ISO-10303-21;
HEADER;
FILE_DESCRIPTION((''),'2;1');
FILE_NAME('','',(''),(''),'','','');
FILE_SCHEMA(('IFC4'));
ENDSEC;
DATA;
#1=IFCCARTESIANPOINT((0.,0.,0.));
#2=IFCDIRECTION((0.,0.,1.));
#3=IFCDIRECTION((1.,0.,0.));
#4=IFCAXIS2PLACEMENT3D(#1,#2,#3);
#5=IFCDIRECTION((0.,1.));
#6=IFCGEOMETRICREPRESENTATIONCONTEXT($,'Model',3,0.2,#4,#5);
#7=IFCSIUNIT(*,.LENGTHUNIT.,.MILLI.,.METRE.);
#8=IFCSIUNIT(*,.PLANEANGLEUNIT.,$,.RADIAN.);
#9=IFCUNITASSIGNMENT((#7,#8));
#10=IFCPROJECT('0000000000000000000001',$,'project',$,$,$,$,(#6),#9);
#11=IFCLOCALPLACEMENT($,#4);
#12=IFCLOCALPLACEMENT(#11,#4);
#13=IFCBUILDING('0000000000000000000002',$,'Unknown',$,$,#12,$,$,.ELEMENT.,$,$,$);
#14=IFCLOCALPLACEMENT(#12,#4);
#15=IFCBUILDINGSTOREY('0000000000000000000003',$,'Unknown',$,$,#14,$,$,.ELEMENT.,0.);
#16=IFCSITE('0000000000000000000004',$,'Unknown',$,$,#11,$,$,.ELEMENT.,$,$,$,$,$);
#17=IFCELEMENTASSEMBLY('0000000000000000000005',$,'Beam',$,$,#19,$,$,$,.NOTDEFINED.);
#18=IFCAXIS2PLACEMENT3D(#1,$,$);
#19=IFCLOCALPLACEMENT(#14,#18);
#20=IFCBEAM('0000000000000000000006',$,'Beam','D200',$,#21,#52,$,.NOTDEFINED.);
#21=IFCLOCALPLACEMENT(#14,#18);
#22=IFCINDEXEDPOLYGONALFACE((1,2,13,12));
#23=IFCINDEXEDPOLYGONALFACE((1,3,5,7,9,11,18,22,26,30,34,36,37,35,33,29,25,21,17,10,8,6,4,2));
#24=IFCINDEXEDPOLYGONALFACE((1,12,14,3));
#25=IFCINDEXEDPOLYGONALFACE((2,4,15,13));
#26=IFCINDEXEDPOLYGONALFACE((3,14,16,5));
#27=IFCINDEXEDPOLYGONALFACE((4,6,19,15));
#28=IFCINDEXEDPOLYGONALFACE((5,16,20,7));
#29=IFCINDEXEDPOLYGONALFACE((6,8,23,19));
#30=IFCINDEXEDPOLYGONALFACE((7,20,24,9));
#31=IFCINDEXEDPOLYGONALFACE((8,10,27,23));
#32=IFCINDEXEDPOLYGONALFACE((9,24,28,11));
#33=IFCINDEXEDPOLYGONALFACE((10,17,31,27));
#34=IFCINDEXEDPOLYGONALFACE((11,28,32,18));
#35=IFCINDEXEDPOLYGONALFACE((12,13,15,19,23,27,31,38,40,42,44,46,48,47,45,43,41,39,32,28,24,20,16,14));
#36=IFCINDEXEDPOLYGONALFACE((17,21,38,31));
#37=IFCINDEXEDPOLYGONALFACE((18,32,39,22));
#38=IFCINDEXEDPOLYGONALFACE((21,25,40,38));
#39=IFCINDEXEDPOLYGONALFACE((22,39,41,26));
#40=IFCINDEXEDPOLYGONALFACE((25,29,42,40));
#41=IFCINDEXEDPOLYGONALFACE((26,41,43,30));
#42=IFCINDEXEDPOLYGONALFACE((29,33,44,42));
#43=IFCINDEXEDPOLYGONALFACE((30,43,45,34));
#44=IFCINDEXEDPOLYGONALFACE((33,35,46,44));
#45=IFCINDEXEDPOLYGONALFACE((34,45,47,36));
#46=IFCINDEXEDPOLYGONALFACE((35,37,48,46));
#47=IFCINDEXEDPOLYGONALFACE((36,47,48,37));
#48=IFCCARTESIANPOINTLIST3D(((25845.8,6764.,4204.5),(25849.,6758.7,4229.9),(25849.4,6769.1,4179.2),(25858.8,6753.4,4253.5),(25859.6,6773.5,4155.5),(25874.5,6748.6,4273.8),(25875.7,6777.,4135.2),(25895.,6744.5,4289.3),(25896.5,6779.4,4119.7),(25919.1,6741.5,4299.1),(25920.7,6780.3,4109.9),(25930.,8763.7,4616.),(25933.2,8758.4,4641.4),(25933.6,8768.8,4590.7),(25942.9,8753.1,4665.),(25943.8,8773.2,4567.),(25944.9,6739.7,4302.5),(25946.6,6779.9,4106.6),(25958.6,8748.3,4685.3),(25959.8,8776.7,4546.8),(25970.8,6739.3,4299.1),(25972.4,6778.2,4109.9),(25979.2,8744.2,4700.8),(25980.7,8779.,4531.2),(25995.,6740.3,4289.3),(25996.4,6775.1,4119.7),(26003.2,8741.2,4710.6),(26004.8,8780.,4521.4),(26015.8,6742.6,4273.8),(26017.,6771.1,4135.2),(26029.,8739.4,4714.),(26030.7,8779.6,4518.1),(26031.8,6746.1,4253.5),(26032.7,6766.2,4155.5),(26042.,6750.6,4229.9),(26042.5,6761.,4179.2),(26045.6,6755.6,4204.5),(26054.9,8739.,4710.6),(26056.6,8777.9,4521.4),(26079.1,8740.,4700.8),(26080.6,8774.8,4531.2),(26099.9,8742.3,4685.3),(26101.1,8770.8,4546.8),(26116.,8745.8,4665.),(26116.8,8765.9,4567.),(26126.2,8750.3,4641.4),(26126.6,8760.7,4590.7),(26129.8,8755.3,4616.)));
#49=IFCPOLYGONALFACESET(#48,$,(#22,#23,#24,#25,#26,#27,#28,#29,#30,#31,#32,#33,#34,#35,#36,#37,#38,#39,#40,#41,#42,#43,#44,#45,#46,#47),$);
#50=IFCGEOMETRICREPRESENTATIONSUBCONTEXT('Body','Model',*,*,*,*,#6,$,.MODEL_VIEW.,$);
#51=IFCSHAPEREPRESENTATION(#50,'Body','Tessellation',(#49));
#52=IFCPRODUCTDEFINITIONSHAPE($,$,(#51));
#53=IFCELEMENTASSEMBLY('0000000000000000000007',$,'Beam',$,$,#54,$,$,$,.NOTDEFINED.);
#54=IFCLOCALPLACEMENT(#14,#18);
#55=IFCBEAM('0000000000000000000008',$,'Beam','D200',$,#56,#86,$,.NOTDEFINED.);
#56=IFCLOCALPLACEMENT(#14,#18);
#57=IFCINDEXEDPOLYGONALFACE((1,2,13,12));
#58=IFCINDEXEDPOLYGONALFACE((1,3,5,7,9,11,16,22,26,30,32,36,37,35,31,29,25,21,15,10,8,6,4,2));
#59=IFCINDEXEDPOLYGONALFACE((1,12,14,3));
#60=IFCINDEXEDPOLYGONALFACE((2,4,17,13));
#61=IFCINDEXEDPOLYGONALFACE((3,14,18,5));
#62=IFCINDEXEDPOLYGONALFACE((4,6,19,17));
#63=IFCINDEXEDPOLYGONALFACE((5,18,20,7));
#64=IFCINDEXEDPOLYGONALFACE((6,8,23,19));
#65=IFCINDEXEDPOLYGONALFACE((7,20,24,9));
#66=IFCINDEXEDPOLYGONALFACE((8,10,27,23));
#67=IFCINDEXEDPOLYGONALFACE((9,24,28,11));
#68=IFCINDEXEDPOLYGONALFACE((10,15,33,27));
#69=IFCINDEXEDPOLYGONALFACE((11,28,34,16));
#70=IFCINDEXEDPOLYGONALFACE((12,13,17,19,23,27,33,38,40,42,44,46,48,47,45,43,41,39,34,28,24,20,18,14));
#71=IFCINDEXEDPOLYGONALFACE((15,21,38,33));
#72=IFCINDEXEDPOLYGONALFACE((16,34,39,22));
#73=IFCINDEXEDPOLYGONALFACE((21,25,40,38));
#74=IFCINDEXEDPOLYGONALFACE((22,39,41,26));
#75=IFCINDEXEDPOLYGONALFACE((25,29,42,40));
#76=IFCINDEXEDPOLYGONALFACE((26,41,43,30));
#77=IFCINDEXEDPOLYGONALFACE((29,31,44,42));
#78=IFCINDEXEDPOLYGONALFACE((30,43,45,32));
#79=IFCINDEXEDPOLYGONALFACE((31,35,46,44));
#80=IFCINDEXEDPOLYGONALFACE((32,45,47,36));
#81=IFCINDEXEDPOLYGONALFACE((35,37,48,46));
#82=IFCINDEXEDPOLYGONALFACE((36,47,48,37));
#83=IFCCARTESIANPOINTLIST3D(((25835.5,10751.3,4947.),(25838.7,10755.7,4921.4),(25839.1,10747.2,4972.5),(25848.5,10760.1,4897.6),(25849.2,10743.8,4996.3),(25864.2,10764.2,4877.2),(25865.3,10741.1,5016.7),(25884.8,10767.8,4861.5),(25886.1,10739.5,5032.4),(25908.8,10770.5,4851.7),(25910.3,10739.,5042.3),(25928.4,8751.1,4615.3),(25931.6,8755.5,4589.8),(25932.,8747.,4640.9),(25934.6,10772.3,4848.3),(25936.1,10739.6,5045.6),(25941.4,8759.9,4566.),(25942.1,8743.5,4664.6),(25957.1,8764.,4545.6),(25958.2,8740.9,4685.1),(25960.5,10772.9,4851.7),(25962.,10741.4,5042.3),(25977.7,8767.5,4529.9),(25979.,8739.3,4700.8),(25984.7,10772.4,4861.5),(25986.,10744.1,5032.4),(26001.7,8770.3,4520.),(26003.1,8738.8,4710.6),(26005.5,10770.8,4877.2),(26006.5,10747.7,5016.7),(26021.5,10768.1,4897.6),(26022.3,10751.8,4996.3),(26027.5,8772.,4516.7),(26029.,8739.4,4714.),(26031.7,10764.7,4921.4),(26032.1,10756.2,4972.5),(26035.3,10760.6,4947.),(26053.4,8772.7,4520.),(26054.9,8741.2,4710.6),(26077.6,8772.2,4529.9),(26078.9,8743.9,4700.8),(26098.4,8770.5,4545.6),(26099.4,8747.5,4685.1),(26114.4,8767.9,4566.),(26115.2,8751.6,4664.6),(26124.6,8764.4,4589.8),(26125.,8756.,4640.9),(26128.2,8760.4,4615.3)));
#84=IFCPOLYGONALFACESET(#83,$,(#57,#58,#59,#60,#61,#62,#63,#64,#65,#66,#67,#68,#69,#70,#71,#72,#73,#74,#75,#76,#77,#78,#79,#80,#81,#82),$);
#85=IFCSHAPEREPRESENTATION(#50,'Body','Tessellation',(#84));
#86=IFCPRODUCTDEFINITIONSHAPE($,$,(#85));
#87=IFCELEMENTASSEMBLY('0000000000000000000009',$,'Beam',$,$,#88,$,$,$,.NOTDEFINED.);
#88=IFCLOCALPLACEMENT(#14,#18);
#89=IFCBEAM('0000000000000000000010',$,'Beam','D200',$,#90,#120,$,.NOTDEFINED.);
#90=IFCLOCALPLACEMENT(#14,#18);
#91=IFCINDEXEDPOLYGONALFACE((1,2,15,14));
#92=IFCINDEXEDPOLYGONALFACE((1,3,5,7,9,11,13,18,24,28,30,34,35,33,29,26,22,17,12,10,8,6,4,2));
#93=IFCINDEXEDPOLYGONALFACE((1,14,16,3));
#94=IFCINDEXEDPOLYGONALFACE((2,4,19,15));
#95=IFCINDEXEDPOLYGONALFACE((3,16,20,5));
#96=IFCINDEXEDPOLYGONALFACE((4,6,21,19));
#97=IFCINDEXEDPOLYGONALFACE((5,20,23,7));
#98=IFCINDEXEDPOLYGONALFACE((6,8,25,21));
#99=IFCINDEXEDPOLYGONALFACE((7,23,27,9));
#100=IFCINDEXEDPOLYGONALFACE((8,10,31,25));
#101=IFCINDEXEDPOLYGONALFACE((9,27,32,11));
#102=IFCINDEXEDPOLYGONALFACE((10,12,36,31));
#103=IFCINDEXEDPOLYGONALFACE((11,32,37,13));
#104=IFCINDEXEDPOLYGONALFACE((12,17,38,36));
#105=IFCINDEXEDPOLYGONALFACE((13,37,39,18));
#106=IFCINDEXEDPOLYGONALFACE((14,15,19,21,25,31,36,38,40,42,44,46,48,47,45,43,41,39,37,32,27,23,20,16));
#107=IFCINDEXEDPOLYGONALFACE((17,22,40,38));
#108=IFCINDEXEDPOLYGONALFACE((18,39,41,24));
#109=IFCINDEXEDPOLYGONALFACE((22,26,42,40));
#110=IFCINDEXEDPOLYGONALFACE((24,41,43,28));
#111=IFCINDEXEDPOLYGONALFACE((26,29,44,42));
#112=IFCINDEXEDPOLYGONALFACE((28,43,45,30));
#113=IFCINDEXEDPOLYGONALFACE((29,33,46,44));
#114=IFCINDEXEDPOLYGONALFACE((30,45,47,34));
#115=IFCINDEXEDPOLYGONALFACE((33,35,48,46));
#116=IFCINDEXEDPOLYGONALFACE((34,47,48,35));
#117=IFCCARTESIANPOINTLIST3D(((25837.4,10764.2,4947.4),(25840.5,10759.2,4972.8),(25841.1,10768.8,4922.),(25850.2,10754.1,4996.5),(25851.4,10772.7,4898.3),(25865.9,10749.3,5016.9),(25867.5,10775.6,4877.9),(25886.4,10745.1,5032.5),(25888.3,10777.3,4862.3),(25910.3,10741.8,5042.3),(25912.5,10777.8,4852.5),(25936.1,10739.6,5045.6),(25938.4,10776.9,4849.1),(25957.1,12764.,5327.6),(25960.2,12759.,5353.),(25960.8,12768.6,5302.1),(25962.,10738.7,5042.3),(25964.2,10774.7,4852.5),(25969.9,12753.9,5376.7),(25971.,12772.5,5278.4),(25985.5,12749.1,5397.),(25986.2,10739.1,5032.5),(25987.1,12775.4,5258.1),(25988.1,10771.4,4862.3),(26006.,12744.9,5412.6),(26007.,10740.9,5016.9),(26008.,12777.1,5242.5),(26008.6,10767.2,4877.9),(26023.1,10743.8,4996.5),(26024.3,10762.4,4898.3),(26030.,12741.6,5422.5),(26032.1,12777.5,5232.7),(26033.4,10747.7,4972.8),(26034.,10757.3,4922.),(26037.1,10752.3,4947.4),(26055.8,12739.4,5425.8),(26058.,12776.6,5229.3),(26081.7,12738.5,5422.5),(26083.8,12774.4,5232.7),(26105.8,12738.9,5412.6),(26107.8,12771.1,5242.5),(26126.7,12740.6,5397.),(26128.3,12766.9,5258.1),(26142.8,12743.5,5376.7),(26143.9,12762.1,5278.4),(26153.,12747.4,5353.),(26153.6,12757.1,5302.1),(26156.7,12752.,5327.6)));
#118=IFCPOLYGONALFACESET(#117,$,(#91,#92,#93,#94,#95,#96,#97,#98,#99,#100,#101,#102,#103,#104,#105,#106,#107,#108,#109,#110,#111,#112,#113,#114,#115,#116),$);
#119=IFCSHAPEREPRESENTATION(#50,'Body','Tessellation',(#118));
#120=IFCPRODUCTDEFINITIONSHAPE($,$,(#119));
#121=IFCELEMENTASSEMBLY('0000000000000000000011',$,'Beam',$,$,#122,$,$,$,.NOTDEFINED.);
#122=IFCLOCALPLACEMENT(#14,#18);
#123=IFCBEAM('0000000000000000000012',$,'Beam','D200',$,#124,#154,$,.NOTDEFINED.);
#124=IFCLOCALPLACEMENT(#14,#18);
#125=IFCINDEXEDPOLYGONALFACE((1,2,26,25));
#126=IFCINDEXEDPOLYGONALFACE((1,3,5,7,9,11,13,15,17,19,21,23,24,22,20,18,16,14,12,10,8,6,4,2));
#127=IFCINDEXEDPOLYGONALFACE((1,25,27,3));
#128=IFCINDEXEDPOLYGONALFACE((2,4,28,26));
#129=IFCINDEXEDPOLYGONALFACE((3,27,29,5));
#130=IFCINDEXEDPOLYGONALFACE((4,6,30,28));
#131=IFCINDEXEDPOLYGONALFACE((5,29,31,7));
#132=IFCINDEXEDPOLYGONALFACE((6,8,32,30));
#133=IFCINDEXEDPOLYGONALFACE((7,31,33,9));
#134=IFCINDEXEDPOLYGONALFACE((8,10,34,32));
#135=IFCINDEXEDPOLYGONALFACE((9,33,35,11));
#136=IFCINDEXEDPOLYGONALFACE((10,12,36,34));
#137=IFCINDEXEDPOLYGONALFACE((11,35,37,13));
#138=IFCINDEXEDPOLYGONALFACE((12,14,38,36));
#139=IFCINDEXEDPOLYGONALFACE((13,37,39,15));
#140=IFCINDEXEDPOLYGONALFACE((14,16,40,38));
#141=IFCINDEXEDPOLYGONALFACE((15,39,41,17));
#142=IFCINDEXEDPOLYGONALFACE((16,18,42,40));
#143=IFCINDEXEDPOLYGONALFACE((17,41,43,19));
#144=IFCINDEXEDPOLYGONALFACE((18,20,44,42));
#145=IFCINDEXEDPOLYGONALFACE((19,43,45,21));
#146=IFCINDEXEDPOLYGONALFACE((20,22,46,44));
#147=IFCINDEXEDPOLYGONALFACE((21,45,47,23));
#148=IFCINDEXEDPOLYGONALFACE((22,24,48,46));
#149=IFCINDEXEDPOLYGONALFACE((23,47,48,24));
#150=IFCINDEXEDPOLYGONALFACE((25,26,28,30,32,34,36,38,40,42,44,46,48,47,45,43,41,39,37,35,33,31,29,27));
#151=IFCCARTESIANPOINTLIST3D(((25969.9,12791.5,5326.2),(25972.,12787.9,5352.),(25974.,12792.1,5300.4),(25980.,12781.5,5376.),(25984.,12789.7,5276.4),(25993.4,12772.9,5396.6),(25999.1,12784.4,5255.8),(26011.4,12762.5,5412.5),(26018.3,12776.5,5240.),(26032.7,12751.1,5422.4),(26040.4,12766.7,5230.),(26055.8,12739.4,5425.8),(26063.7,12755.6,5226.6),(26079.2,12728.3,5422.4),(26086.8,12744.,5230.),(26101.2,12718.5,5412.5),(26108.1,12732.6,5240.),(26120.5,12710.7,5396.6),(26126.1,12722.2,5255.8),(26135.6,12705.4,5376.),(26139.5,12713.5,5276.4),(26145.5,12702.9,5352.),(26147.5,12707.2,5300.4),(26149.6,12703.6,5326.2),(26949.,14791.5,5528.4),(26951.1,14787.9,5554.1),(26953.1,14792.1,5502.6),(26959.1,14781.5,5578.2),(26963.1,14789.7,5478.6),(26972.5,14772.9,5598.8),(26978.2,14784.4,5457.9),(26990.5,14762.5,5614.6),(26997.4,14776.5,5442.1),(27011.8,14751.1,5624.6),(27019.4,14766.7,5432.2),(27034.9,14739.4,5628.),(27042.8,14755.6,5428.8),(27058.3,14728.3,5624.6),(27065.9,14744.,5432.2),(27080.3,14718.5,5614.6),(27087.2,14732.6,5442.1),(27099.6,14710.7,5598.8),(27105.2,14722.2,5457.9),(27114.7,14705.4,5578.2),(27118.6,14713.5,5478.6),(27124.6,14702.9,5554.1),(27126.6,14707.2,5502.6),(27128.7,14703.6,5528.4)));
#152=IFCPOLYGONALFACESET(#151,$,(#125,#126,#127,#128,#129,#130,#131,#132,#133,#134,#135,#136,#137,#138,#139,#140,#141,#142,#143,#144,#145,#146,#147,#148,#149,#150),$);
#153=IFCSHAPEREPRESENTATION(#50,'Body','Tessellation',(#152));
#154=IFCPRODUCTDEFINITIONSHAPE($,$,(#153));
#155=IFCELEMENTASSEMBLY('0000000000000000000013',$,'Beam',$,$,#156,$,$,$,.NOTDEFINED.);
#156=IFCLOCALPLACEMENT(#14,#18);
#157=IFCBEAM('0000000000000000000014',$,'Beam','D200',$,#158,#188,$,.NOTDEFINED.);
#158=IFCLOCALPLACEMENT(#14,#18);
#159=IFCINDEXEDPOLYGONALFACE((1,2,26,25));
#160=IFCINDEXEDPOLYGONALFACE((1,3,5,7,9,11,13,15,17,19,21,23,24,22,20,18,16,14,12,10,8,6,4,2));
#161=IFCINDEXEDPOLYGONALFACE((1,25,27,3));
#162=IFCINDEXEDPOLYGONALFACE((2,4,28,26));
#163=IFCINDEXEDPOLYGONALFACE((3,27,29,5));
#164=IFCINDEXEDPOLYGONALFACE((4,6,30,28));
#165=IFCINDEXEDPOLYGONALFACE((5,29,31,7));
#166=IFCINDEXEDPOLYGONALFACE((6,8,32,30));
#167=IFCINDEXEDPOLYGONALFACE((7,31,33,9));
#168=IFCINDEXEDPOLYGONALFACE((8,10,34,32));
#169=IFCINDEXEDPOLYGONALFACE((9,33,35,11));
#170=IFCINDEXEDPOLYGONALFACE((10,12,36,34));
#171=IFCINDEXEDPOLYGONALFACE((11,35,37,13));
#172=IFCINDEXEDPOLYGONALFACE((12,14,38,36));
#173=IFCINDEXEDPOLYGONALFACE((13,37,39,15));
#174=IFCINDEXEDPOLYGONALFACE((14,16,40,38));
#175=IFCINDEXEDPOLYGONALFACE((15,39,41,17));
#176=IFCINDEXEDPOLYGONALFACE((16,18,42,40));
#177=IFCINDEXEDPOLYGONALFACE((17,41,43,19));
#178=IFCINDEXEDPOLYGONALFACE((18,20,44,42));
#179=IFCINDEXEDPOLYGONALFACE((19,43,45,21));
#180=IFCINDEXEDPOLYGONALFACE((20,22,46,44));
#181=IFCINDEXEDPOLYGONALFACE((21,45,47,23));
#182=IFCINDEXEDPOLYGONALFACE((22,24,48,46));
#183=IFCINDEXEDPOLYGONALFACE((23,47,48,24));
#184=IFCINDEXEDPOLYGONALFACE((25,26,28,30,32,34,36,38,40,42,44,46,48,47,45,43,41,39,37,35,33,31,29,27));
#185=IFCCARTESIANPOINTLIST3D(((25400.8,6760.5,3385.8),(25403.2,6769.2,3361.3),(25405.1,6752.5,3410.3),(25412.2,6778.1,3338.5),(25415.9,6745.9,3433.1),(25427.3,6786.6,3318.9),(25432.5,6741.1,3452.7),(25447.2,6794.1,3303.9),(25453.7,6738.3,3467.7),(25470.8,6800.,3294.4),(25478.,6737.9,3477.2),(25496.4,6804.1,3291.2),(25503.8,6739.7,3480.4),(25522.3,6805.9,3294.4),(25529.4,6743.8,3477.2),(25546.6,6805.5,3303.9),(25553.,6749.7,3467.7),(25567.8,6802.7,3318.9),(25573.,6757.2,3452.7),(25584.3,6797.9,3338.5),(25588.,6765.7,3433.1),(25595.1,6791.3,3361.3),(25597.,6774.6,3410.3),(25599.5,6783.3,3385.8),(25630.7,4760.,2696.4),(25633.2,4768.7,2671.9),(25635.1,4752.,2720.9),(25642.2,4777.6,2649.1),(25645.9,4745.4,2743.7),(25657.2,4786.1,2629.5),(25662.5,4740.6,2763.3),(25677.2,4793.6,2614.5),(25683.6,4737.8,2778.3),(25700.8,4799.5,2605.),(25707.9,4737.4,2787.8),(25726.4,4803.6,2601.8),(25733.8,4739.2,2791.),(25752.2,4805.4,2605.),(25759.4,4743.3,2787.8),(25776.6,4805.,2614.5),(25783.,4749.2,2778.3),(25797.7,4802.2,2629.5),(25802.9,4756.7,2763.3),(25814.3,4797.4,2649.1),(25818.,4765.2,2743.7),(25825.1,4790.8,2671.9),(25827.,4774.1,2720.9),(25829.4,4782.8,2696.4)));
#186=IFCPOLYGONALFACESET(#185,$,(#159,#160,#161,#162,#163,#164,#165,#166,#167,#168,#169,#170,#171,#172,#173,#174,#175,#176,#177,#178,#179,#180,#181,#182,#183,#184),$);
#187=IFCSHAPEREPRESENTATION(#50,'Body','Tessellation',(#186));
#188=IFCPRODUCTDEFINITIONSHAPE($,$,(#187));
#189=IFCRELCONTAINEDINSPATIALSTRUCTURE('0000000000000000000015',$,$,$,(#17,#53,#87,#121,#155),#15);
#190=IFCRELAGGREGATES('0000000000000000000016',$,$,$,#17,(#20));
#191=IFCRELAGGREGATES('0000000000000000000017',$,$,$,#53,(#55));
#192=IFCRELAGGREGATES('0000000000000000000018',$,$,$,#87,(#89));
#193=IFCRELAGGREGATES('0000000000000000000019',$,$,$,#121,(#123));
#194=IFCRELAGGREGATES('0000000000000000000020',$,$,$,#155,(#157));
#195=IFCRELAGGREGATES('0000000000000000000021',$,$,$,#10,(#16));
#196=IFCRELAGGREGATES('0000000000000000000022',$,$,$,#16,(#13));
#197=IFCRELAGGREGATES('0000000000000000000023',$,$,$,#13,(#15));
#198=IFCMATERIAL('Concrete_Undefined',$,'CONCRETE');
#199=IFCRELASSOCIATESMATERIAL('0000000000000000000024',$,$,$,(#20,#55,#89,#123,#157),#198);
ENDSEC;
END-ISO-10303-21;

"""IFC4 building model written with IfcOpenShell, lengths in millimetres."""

from ifc_helpers import new_model, si_unit, direction, frame, origin_with_axes, place, context, subcontext, project, spatial, line, indexed_curve, outline, extrude, material, element, aggregate, save


model = new_model("IFC4")

# Units and contexts
model_context = context("Model", 3, precision=0.2, world=origin_with_axes(), true_north=direction((0.0, 1.0)))
body_context = subcontext(model_context, "Body", "Model", "MODEL_VIEW")
ifc_project = project(units=[si_unit("LENGTHUNIT", "METRE", prefix="MILLI"), si_unit("PLANEANGLEUNIT", "RADIAN")], contexts=[model_context])

# Site, building, storey
site_placement = place(None, origin_with_axes())
site = spatial("IfcSite", under=ifc_project, at=site_placement, Name="Unknown", CompositionType="ELEMENT")
building_placement = place(site_placement, origin_with_axes())
building = spatial("IfcBuilding", under=site, at=building_placement, Name="Unknown", CompositionType="ELEMENT")
storey_placement = place(building_placement, origin_with_axes())
storey = spatial("IfcBuildingStorey", under=building, at=storey_placement, Name="Unknown", CompositionType="ELEMENT", Elevation=0.0)

# Shared definitions
ifc_material = material(Name="Concrete_Undefined", Category="CONCRETE")

# Element assemblies, beams
assembly_1_placement = place(storey_placement, frame((26029.9, 8759.5, 4616.0), z_axis=(-0.999116, 0.04204, 0.0), x_axis=(-0.041178, -0.978644, -0.201396)))
assembly_1 = element("IfcElementAssembly", 1, at=assembly_1_placement, inside=storey, Name="Beam", PredefinedType="NOTDEFINED")
beam_1_placement = place(assembly_1_placement, origin_with_axes())
beam_1 = element("IfcBeam", 2, at=beam_1_placement, material=ifc_material, Name="Beam", Description="D200", PredefinedType="NOTDEFINED", context=body_context, shape_type="SolidModel", body=[
    extrude(outline(indexed_curve([(100.0, 0.0), (96.6, 25.9), (86.6, 50.0), (70.7, 70.7), (50.0, 86.6), (25.9, 96.6), (0.0, 100.0), (-25.9, 96.6), (-50.0, 86.6), (-70.7, 70.7), (-86.6, 50.0), (-96.6, 25.9), (-100.0, 0.0), (-96.6, -25.9), (-86.6, -50.0), (-70.7, -70.7), (-50.0, -86.6), (-25.9, -96.6), (0.0, -100.0), (25.9, -96.6), (50.0, -86.6), (70.7, -70.7), (86.6, -50.0), (96.6, -25.9)], segments=[line(1, 2, 3, 4, 5, 6, 7, 8, 9, 10, 11, 12, 13, 14, 15, 16, 17, 18, 19, 20, 21, 22, 23, 24, 1)])), frame((0.0, 0.0, 0.0), z_axis=(-1.0, 0.0, 0.0), x_axis=(0.0, 0.0, 1.0)), (0.0, 0.0, -1.0), 2043.3),
])
aggregate(assembly_1, [beam_1])
assembly_2_placement = place(storey_placement, frame((25935.4, 10756.0, 4947.0), z_axis=(-0.998923, -0.046392, 0.0), x_axis=(0.045768, -0.985497, -0.163405)))
assembly_2 = element("IfcElementAssembly", 3, at=assembly_2_placement, inside=storey, Name="Beam", PredefinedType="NOTDEFINED")
beam_2_placement = place(assembly_2_placement, origin_with_axes())
beam_2 = element("IfcBeam", 4, at=beam_2_placement, material=ifc_material, Name="Beam", Description="D200", PredefinedType="NOTDEFINED", context=body_context, shape_type="SolidModel", body=[
    extrude(outline(indexed_curve([(100.0, 0.0), (96.6, 25.9), (86.6, 50.0), (70.7, 70.7), (50.0, 86.6), (25.9, 96.6), (0.0, 100.0), (-25.9, 96.6), (-50.0, 86.6), (-70.7, 70.7), (-86.6, 50.0), (-96.6, 25.9), (-100.0, 0.0), (-96.6, -25.9), (-86.6, -50.0), (-70.7, -70.7), (-50.0, -86.6), (-25.9, -96.6), (0.0, -100.0), (25.9, -96.6), (50.0, -86.6), (70.7, -70.7), (86.6, -50.0), (96.6, -25.9)], segments=[line(1, 2, 3, 4, 5, 6, 7, 8, 9, 10, 11, 12, 13, 14, 15, 16, 17, 18, 19, 20, 21, 22, 23, 24, 1)])), frame((0.0, 0.0, 0.0), z_axis=(-1.0, 0.0, 0.0), x_axis=(0.0, 0.0, 1.0)), (0.0, 0.0, -1.0), 2029.7),
])
aggregate(assembly_2, [beam_2])
assembly_3_placement = place(storey_placement, frame((26056.9, 12758.0, 5327.6), z_axis=(-0.998215, 0.059727, 0.0), x_axis=(-0.05868, -0.980712, -0.18644)))
assembly_3 = element("IfcElementAssembly", 5, at=assembly_3_placement, inside=storey, Name="Beam", PredefinedType="NOTDEFINED")
beam_3_placement = place(assembly_3_placement, origin_with_axes())
beam_3 = element("IfcBeam", 6, at=beam_3_placement, material=ifc_material, Name="Beam", Description="D200", PredefinedType="NOTDEFINED", context=body_context, shape_type="SolidModel", body=[
    extrude(outline(indexed_curve([(100.0, 0.0), (96.6, 25.9), (86.6, 50.0), (70.7, 70.7), (50.0, 86.6), (25.9, 96.6), (0.0, 100.0), (-25.9, 96.6), (-50.0, 86.6), (-70.7, 70.7), (-86.6, 50.0), (-96.6, 25.9), (-100.0, 0.0), (-96.6, -25.9), (-86.6, -50.0), (-70.7, -70.7), (-50.0, -86.6), (-25.9, -96.6), (0.0, -100.0), (25.9, -96.6), (50.0, -86.6), (70.7, -70.7), (86.6, -50.0), (96.6, -25.9)], segments=[line(1, 2, 3, 4, 5, 6, 7, 8, 9, 10, 11, 12, 13, 14, 15, 16, 17, 18, 19, 20, 21, 22, 23, 24, 1)])), frame((0.0, 0.0, 0.0), z_axis=(-1.0, 0.0, 0.0), x_axis=(0.0, 0.0, 1.0)), (0.0, 0.0, -1.0), 2039.1),
])
aggregate(assembly_3, [beam_3])
assembly_4_placement = place(storey_placement, frame((27038.9, 14747.5, 5528.4), z_axis=(-0.898151, 0.439686, 0.0), x_axis=(-0.437886, -0.894473, -0.090411)))
assembly_4 = element("IfcElementAssembly", 7, at=assembly_4_placement, inside=storey, Name="Beam", PredefinedType="NOTDEFINED")
beam_4_placement = place(assembly_4_placement, origin_with_axes())
beam_4 = element("IfcBeam", 8, at=beam_4_placement, material=ifc_material, Name="Beam", Description="D200", PredefinedType="NOTDEFINED", context=body_context, shape_type="SolidModel", body=[
    extrude(outline(indexed_curve([(100.0, 0.0), (96.6, 25.9), (86.6, 50.0), (70.7, 70.7), (50.0, 86.6), (25.9, 96.6), (0.0, 100.0), (-25.9, 96.6), (-50.0, 86.6), (-70.7, 70.7), (-86.6, 50.0), (-96.6, 25.9), (-100.0, 0.0), (-96.6, -25.9), (-86.6, -50.0), (-70.7, -70.7), (-50.0, -86.6), (-25.9, -96.6), (0.0, -100.0), (25.9, -96.6), (50.0, -86.6), (70.7, -70.7), (86.6, -50.0), (96.6, -25.9)], segments=[line(1, 2, 3, 4, 5, 6, 7, 8, 9, 10, 11, 12, 13, 14, 15, 16, 17, 18, 19, 20, 21, 22, 23, 24, 1)])), frame((0.0, 0.0, 0.0), z_axis=(-1.0, 0.0, 0.0), x_axis=(0.0, 0.0, 1.0)), (0.0, 0.0, -1.0), 2236.0),
])
aggregate(assembly_4, [beam_4])
assembly_5_placement = place(storey_placement, frame((25500.1, 6771.9, 3385.8), z_axis=(-0.993458, -0.114199, 0.0), x_axis=(0.108043, -0.939901, -0.323901)))
assembly_5 = element("IfcElementAssembly", 9, at=assembly_5_placement, inside=storey, Name="Beam", PredefinedType="NOTDEFINED")
beam_5_placement = place(assembly_5_placement, origin_with_axes())
beam_5 = element("IfcBeam", 10, at=beam_5_placement, material=ifc_material, Name="Beam", Description="D200", PredefinedType="NOTDEFINED", context=body_context, shape_type="SolidModel", body=[
    extrude(outline(indexed_curve([(100.0, 0.0), (96.6, 25.9), (86.6, 50.0), (70.7, 70.7), (50.0, 86.6), (25.9, 96.6), (0.0, 100.0), (-25.9, 96.6), (-50.0, 86.6), (-70.7, 70.7), (-86.6, 50.0), (-96.6, 25.9), (-100.0, 0.0), (-96.6, -25.9), (-86.6, -50.0), (-70.7, -70.7), (-50.0, -86.6), (-25.9, -96.6), (0.0, -100.0), (25.9, -96.6), (50.0, -86.6), (70.7, -70.7), (86.6, -50.0), (96.6, -25.9)], segments=[line(1, 2, 3, 4, 5, 6, 7, 8, 9, 10, 11, 12, 13, 14, 15, 16, 17, 18, 19, 20, 21, 22, 23, 24, 1)])), frame((0.0, 0.0, 0.0), z_axis=(-1.0, 0.0, 0.0), x_axis=(0.0, 0.0, 1.0)), (0.0, 0.0, -1.0), 2128.4),
])
aggregate(assembly_5, [beam_5])

save(model, "model.ifc")
